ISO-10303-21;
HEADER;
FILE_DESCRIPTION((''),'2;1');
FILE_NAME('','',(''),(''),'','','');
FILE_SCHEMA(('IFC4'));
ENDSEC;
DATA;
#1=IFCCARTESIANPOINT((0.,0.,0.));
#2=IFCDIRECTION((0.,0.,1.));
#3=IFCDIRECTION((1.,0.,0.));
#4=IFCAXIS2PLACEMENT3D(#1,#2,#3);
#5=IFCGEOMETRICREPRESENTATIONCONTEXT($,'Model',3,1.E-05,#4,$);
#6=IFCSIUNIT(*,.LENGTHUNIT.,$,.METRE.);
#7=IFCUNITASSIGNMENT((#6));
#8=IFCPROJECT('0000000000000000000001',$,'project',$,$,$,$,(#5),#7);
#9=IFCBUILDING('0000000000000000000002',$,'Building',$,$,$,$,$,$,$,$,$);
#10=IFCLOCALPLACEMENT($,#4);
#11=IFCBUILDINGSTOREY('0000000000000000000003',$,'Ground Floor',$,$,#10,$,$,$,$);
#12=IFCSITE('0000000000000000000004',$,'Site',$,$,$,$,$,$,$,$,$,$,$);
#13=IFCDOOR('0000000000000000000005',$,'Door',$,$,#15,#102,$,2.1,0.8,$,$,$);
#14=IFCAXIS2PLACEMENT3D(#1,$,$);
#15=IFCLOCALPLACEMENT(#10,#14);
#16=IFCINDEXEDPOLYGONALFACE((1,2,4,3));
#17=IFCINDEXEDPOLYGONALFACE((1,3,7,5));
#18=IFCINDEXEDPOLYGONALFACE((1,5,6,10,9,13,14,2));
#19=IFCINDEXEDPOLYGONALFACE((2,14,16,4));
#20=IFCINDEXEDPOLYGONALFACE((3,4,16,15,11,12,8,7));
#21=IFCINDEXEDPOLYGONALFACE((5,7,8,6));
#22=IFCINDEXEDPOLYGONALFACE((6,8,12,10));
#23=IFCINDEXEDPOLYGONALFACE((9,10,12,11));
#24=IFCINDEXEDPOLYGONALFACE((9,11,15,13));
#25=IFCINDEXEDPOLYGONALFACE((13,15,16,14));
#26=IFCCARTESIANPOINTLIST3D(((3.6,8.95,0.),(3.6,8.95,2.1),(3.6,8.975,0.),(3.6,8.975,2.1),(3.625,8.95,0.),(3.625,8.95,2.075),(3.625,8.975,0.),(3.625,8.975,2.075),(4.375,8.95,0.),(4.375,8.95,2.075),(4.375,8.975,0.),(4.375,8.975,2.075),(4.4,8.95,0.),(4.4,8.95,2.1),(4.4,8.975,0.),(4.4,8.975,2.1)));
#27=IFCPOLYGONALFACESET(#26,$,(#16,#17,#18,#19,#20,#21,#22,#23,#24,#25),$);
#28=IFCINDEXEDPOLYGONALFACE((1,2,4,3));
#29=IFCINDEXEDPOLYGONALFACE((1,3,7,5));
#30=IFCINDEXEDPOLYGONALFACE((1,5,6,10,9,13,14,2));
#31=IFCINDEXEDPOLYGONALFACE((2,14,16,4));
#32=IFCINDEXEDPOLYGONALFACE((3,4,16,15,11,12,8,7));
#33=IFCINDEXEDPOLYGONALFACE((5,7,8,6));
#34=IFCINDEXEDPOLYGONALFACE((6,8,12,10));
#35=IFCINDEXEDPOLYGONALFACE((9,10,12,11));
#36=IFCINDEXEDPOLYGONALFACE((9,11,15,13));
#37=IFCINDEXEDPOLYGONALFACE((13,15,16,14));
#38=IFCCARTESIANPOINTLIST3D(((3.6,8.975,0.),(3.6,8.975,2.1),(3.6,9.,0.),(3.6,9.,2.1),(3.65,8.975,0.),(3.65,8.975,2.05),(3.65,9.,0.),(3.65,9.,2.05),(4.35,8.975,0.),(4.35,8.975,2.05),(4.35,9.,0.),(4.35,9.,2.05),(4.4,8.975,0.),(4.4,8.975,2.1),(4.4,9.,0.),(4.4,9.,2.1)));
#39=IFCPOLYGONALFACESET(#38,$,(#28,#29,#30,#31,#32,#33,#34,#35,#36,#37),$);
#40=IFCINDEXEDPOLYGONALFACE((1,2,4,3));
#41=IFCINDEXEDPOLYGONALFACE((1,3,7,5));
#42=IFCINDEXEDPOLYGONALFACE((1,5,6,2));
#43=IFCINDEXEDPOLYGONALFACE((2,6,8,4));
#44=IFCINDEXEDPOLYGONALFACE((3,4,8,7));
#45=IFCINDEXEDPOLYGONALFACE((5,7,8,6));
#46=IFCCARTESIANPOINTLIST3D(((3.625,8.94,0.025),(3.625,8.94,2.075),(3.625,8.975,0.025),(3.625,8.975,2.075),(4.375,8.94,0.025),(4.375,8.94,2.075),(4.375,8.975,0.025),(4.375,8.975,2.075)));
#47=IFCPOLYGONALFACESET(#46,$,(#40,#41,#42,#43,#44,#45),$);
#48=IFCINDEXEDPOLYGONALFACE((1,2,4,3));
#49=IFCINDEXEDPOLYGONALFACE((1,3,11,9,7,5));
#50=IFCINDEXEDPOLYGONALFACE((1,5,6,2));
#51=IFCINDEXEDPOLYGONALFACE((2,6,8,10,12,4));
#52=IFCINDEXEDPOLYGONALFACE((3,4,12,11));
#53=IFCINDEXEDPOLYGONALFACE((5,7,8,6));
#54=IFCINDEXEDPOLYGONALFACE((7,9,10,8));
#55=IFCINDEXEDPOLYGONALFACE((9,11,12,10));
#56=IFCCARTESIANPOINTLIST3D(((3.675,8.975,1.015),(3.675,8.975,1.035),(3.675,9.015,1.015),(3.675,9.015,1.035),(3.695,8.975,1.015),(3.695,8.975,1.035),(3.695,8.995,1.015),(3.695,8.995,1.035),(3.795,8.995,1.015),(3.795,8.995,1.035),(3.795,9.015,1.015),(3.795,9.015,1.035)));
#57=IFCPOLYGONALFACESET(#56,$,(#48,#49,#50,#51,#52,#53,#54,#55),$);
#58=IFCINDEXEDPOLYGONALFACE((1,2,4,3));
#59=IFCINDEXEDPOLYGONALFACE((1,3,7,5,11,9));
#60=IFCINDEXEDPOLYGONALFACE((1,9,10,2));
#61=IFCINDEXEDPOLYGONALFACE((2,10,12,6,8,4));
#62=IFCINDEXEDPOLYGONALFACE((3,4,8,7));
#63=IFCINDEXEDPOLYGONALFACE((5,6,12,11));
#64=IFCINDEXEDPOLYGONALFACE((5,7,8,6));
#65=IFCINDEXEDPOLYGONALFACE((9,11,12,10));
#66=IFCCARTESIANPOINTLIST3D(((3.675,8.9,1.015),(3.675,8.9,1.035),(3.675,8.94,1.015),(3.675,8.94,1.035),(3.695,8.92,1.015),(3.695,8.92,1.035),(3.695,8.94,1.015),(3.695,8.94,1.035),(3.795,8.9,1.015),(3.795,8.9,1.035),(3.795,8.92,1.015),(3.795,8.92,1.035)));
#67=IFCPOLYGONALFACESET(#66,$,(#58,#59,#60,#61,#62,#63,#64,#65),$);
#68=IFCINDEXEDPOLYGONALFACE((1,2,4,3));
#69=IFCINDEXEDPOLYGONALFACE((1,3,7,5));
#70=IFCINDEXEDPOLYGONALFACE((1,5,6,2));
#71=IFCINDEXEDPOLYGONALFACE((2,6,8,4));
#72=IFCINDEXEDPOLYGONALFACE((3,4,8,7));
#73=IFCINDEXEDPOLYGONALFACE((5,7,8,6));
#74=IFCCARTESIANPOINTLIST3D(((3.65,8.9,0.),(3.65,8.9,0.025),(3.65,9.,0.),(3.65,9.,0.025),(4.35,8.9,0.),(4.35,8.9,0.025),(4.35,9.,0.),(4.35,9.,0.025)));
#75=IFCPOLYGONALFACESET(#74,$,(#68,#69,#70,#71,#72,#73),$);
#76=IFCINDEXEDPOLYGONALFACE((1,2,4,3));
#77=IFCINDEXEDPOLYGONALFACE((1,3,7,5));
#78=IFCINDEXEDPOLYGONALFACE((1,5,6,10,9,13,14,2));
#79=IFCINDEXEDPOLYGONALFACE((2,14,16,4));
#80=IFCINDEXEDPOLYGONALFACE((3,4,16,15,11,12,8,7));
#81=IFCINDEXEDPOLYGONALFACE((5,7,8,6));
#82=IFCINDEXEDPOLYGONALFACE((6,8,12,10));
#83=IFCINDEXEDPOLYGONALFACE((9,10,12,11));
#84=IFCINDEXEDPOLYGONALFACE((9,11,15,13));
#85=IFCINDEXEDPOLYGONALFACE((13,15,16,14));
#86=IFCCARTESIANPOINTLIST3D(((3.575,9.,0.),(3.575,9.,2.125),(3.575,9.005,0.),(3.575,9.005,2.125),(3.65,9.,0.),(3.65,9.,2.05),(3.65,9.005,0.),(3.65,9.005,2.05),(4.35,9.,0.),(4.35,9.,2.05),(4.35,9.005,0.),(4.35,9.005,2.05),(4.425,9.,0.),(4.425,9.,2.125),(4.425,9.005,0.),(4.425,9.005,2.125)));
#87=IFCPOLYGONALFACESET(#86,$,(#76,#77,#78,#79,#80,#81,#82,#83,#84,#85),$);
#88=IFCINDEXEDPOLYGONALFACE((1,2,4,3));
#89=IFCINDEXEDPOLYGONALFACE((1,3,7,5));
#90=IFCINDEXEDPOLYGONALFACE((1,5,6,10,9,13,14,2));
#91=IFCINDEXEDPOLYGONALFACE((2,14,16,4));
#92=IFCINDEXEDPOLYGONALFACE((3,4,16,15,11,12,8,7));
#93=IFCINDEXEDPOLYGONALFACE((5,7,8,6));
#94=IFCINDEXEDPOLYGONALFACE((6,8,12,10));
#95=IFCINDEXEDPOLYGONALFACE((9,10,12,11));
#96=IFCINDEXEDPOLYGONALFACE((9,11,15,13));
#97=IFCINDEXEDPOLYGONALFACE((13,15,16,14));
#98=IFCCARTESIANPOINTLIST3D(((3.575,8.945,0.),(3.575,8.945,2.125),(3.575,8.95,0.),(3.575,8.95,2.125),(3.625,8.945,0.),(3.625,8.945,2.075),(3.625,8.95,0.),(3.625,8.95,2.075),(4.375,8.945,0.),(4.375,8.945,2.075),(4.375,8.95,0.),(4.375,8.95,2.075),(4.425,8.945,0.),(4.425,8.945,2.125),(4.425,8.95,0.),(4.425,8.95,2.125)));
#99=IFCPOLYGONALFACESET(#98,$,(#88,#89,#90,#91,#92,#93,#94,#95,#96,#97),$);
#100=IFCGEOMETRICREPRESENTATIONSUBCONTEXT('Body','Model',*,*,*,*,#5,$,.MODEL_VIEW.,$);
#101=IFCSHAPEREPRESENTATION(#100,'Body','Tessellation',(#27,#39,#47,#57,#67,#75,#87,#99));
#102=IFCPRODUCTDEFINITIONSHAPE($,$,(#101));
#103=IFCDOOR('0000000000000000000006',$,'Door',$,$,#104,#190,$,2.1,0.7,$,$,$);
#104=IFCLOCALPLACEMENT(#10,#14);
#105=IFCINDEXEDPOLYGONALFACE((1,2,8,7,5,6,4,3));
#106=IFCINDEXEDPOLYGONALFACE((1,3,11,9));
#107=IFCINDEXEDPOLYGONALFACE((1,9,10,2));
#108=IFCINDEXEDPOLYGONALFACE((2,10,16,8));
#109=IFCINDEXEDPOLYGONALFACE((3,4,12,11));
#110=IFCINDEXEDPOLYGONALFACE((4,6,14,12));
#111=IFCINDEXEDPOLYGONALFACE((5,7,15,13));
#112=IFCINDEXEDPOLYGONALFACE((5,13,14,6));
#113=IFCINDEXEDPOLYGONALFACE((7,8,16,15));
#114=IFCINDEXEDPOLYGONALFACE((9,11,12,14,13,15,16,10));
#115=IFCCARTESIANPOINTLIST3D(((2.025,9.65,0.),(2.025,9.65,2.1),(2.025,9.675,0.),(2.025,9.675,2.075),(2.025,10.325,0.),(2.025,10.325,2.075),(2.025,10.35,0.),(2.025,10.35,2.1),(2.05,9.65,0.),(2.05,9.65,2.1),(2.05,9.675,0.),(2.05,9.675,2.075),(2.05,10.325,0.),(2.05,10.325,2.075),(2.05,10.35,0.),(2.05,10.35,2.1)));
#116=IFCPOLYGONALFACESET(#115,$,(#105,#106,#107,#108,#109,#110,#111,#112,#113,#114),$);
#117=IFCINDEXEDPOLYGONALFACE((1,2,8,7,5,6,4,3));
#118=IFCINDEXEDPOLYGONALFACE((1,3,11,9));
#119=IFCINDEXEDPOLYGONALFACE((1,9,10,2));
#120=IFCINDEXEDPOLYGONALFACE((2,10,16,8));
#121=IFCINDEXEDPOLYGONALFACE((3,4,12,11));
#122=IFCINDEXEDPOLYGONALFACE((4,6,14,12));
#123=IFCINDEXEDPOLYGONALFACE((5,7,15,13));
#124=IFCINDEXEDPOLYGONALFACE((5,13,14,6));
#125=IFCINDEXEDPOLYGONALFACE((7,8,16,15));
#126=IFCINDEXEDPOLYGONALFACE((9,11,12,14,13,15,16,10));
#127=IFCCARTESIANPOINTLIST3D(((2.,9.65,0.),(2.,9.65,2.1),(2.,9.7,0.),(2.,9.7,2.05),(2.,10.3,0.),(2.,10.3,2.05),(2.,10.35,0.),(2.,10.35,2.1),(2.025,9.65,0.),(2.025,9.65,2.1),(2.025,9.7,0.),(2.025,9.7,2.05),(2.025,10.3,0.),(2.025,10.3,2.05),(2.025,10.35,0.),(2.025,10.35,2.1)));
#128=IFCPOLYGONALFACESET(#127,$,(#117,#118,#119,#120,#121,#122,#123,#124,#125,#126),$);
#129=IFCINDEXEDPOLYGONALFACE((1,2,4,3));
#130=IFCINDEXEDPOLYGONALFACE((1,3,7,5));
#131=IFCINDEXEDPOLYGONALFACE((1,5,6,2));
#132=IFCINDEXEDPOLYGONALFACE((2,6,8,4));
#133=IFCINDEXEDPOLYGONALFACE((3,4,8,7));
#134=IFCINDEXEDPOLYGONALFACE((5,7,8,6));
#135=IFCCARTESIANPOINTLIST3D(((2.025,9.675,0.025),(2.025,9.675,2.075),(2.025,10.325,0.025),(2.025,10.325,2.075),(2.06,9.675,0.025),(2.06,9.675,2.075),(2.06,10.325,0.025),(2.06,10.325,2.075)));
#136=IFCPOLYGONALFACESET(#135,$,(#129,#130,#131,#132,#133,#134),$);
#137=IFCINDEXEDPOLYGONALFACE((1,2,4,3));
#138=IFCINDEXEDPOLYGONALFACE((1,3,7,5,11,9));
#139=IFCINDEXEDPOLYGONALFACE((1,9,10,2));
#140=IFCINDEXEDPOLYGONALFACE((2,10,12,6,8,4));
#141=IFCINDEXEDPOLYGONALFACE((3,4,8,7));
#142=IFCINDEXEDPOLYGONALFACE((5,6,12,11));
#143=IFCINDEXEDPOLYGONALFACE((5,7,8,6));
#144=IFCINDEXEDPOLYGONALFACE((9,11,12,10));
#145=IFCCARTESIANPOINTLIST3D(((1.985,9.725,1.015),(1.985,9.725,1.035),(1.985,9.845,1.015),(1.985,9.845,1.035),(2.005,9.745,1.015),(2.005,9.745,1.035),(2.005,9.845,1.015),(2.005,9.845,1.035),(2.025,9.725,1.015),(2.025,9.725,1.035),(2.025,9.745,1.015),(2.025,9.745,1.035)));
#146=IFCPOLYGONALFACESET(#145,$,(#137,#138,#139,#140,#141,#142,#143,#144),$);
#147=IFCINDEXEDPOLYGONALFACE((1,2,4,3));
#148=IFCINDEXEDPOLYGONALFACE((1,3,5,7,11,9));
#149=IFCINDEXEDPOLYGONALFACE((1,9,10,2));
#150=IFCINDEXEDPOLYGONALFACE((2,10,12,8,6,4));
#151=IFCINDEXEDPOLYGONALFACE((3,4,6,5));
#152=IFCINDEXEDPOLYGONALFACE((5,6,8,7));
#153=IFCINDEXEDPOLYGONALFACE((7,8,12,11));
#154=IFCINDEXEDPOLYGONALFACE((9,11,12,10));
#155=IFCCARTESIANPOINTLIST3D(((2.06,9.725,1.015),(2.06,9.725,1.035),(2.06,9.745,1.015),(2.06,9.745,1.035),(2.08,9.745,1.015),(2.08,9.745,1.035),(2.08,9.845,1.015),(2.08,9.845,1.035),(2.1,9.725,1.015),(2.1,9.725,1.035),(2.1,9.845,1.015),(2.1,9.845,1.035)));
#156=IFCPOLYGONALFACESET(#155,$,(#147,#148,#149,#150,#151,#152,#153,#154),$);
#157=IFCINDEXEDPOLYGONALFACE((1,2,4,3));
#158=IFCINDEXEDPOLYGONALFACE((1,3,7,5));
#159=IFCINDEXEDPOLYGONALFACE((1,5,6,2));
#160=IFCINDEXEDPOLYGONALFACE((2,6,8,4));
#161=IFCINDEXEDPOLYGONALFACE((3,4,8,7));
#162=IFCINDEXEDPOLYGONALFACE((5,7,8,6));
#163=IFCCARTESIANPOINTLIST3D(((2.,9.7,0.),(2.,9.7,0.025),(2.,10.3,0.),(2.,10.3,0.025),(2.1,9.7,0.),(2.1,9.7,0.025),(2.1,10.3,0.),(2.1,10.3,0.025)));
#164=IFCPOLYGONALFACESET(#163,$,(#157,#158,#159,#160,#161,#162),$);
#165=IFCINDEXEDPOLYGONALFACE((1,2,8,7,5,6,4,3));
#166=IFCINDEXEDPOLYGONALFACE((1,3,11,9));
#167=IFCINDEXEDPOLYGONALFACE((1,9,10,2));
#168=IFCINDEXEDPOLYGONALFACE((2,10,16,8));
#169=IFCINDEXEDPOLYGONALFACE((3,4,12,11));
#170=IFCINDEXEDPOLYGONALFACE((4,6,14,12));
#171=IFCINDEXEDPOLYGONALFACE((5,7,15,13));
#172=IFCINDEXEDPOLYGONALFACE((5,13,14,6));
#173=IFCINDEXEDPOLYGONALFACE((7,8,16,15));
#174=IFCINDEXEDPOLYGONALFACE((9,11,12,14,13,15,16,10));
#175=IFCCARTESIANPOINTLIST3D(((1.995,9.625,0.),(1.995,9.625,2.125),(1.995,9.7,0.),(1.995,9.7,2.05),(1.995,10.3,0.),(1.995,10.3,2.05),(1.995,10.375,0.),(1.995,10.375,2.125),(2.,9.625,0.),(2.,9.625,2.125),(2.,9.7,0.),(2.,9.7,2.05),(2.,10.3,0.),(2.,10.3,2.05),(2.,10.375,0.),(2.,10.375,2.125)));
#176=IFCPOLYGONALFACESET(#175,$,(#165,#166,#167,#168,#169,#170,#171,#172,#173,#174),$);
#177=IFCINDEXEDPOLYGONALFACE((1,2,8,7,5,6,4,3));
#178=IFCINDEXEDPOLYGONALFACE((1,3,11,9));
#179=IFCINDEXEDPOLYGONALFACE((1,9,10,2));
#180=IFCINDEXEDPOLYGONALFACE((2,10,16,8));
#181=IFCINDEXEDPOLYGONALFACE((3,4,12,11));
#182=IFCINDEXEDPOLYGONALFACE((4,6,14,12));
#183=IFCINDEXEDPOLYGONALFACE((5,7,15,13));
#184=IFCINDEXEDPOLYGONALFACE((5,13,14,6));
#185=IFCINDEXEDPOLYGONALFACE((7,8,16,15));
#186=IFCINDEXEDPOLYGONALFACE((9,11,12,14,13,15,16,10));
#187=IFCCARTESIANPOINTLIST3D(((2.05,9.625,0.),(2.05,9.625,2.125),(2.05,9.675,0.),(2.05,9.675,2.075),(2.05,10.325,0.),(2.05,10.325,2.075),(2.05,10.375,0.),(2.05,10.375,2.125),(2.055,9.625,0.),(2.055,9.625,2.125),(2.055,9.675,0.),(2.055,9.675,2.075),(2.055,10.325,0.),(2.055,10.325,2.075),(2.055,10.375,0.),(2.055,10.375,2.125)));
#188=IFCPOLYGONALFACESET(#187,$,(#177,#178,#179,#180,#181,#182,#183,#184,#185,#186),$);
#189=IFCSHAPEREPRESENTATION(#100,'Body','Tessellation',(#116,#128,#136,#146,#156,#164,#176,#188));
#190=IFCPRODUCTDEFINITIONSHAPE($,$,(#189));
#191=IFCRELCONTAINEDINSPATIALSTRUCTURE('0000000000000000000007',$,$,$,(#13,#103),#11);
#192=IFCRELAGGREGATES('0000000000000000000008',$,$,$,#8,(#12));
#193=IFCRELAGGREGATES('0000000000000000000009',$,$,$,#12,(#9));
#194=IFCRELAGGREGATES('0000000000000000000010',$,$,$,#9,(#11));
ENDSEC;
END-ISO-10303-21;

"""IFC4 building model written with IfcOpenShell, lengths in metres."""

from ifc_helpers import new_model, si_unit, frame, origin_with_axes, place, context, subcontext, project, spatial, line, indexed_curve, outline, extrude, element, save


model = new_model("IFC4")

# Units and contexts
model_context = context("Model", 3, precision=1e-05, world=origin_with_axes())
body_context = subcontext(model_context, "Body", "Model", "MODEL_VIEW")
ifc_project = project(units=[si_unit("LENGTHUNIT", "METRE")], contexts=[model_context])

# Site, building, storey
site = spatial("IfcSite", under=ifc_project, Name="Site")
building = spatial("IfcBuilding", under=site, Name="Building")
storey_placement = place(None, origin_with_axes())
storey = spatial("IfcBuildingStorey", under=building, at=storey_placement, Name="Ground Floor")

# Doors
door_1_placement = place(storey_placement, frame((4.4, 9.0, 0.0), z_axis=(0.0, 0.0, 1.0), x_axis=(-1.0, 0.0, 0.0)))
element("IfcDoor", 1, at=door_1_placement, inside=storey, Name="Door", OverallHeight=2.1, OverallWidth=0.8, context=body_context, shape_type="SweptSolid", body=[
    extrude(outline(indexed_curve([(0.0, 0.0), (0.0, 2.1), (0.8, 2.1), (0.8, 0.0), (0.775, 0.0), (0.775, 2.075), (0.025, 2.075), (0.025, 0.0)], segments=[line(1, 2, 3, 4, 5, 6, 7, 8, 1)])), frame((0.0, 0.025, 0.0), z_axis=(0.0, -1.0, 0.0), x_axis=(1.0, 0.0, 0.0)), (0.0, 0.0, -1.0), 0.025),
    extrude(outline(indexed_curve([(0.0, 0.0), (0.0, 2.1), (0.8, 2.1), (0.8, 0.0), (0.75, 0.0), (0.75, 2.05), (0.05, 2.05), (0.05, 0.0)], segments=[line(1, 2, 3, 4, 5, 6, 7, 8, 1)])), frame((0.0, 0.0, 0.0), z_axis=(0.0, -1.0, 0.0), x_axis=(1.0, 0.0, 0.0)), (0.0, 0.0, -1.0), 0.025),
    extrude(outline(indexed_curve([(0.0, 0.0), (0.75, 0.0), (0.75, 0.035), (0.0, 0.035)], segments=[line(1, 2, 3, 4, 1)])), frame((0.025, 0.025, 0.025), z_axis=(0.0, 0.0, 1.0), x_axis=(1.0, 0.0, 0.0)), (0.0, 0.0, 1.0), 2.05),
    extrude(outline(indexed_curve([(0.0, 0.0), (0.0, -0.04), (-0.12, -0.04), (-0.12, -0.02), (-0.02, -0.02), (-0.02, 0.0)], segments=[line(1, 2, 3, 4, 5, 6, 1)])), frame((0.725, 0.025, 1.015), z_axis=(0.0, 0.0, 1.0), x_axis=(1.0, 0.0, 0.0)), (0.0, 0.0, 1.0), 0.02),
    extrude(outline(indexed_curve([(0.0, 0.0), (0.0, 0.04), (-0.12, 0.04), (-0.12, 0.02), (-0.02, 0.02), (-0.02, 0.0)], segments=[line(1, 2, 3, 4, 5, 6, 1)])), frame((0.725, 0.06, 1.015), z_axis=(0.0, 0.0, 1.0), x_axis=(1.0, 0.0, 0.0)), (0.0, 0.0, 1.0), 0.02),
    extrude(outline(indexed_curve([(0.0, 0.0), (0.7, 0.0), (0.7, 0.1), (0.0, 0.1)], segments=[line(1, 2, 3, 4, 1)])), frame((0.05, 0.0, 0.0), z_axis=(0.0, 0.0, 1.0), x_axis=(1.0, 0.0, 0.0)), (0.0, 0.0, 1.0), 0.025),
    extrude(outline(indexed_curve([(0.0, 0.0), (0.0, 2.125), (0.85, 2.125), (0.85, 0.0), (0.775, 0.0), (0.775, 2.05), (0.075, 2.05), (0.075, 0.0)], segments=[line(1, 2, 3, 4, 5, 6, 7, 8, 1)])), frame((-0.025, -0.005, 0.0), z_axis=(0.0, -1.0, 0.0), x_axis=(1.0, 0.0, 0.0)), (0.0, 0.0, -1.0), 0.005),
    extrude(outline(indexed_curve([(0.0, 0.0), (0.0, 2.125), (0.85, 2.125), (0.85, 0.0), (0.8, 0.0), (0.8, 2.075), (0.05, 2.075), (0.05, 0.0)], segments=[line(1, 2, 3, 4, 5, 6, 7, 8, 1)])), frame((-0.025, 0.05, 0.0), z_axis=(0.0, -1.0, 0.0), x_axis=(1.0, 0.0, 0.0)), (0.0, 0.0, -1.0), 0.005),
])
door_2_placement = place(storey_placement, frame((2.0, 10.35, 0.0), z_axis=(0.0, 0.0, 1.0), x_axis=(0.0, -1.0, 0.0)))
element("IfcDoor", 2, at=door_2_placement, inside=storey, Name="Door", OverallHeight=2.1, OverallWidth=0.7, context=body_context, shape_type="SweptSolid", body=[
    extrude(outline(indexed_curve([(0.0, 0.0), (0.0, 2.1), (0.7, 2.1), (0.7, 0.0), (0.675, 0.0), (0.675, 2.075), (0.025, 2.075), (0.025, 0.0)], segments=[line(1, 2, 3, 4, 5, 6, 7, 8, 1)])), frame((0.0, 0.025, 0.0), z_axis=(0.0, -1.0, 0.0), x_axis=(1.0, 0.0, 0.0)), (0.0, 0.0, -1.0), 0.025),
    extrude(outline(indexed_curve([(0.0, 0.0), (0.0, 2.1), (0.7, 2.1), (0.7, 0.0), (0.65, 0.0), (0.65, 2.05), (0.05, 2.05), (0.05, 0.0)], segments=[line(1, 2, 3, 4, 5, 6, 7, 8, 1)])), frame((0.0, 0.0, 0.0), z_axis=(0.0, -1.0, 0.0), x_axis=(1.0, 0.0, 0.0)), (0.0, 0.0, -1.0), 0.025),
    extrude(outline(indexed_curve([(0.0, 0.0), (0.65, 0.0), (0.65, 0.035), (0.0, 0.035)], segments=[line(1, 2, 3, 4, 1)])), frame((0.025, 0.025, 0.025), z_axis=(0.0, 0.0, 1.0), x_axis=(1.0, 0.0, 0.0)), (0.0, 0.0, 1.0), 2.05),
    extrude(outline(indexed_curve([(0.0, 0.0), (0.0, -0.04), (-0.12, -0.04), (-0.12, -0.02), (-0.02, -0.02), (-0.02, 0.0)], segments=[line(1, 2, 3, 4, 5, 6, 1)])), frame((0.625, 0.025, 1.015), z_axis=(0.0, 0.0, 1.0), x_axis=(1.0, 0.0, 0.0)), (0.0, 0.0, 1.0), 0.02),
    extrude(outline(indexed_curve([(0.0, 0.0), (0.0, 0.04), (-0.12, 0.04), (-0.12, 0.02), (-0.02, 0.02), (-0.02, 0.0)], segments=[line(1, 2, 3, 4, 5, 6, 1)])), frame((0.625, 0.06, 1.015), z_axis=(0.0, 0.0, 1.0), x_axis=(1.0, 0.0, 0.0)), (0.0, 0.0, 1.0), 0.02),
    extrude(outline(indexed_curve([(0.0, 0.0), (0.6, 0.0), (0.6, 0.1), (0.0, 0.1)], segments=[line(1, 2, 3, 4, 1)])), frame((0.05, 0.0, 0.0), z_axis=(0.0, 0.0, 1.0), x_axis=(1.0, 0.0, 0.0)), (0.0, 0.0, 1.0), 0.025),
    extrude(outline(indexed_curve([(0.0, 0.0), (0.0, 2.125), (0.75, 2.125), (0.75, 0.0), (0.675, 0.0), (0.675, 2.05), (0.075, 2.05), (0.075, 0.0)], segments=[line(1, 2, 3, 4, 5, 6, 7, 8, 1)])), frame((-0.025, -0.005, 0.0), z_axis=(0.0, -1.0, 0.0), x_axis=(1.0, 0.0, 0.0)), (0.0, 0.0, -1.0), 0.005),
    extrude(outline(indexed_curve([(0.0, 0.0), (0.0, 2.125), (0.75, 2.125), (0.75, 0.0), (0.7, 0.0), (0.7, 2.075), (0.05, 2.075), (0.05, 0.0)], segments=[line(1, 2, 3, 4, 5, 6, 7, 8, 1)])), frame((-0.025, 0.05, 0.0), z_axis=(0.0, -1.0, 0.0), x_axis=(1.0, 0.0, 0.0)), (0.0, 0.0, -1.0), 0.005),
])

save(model, "model.ifc")
